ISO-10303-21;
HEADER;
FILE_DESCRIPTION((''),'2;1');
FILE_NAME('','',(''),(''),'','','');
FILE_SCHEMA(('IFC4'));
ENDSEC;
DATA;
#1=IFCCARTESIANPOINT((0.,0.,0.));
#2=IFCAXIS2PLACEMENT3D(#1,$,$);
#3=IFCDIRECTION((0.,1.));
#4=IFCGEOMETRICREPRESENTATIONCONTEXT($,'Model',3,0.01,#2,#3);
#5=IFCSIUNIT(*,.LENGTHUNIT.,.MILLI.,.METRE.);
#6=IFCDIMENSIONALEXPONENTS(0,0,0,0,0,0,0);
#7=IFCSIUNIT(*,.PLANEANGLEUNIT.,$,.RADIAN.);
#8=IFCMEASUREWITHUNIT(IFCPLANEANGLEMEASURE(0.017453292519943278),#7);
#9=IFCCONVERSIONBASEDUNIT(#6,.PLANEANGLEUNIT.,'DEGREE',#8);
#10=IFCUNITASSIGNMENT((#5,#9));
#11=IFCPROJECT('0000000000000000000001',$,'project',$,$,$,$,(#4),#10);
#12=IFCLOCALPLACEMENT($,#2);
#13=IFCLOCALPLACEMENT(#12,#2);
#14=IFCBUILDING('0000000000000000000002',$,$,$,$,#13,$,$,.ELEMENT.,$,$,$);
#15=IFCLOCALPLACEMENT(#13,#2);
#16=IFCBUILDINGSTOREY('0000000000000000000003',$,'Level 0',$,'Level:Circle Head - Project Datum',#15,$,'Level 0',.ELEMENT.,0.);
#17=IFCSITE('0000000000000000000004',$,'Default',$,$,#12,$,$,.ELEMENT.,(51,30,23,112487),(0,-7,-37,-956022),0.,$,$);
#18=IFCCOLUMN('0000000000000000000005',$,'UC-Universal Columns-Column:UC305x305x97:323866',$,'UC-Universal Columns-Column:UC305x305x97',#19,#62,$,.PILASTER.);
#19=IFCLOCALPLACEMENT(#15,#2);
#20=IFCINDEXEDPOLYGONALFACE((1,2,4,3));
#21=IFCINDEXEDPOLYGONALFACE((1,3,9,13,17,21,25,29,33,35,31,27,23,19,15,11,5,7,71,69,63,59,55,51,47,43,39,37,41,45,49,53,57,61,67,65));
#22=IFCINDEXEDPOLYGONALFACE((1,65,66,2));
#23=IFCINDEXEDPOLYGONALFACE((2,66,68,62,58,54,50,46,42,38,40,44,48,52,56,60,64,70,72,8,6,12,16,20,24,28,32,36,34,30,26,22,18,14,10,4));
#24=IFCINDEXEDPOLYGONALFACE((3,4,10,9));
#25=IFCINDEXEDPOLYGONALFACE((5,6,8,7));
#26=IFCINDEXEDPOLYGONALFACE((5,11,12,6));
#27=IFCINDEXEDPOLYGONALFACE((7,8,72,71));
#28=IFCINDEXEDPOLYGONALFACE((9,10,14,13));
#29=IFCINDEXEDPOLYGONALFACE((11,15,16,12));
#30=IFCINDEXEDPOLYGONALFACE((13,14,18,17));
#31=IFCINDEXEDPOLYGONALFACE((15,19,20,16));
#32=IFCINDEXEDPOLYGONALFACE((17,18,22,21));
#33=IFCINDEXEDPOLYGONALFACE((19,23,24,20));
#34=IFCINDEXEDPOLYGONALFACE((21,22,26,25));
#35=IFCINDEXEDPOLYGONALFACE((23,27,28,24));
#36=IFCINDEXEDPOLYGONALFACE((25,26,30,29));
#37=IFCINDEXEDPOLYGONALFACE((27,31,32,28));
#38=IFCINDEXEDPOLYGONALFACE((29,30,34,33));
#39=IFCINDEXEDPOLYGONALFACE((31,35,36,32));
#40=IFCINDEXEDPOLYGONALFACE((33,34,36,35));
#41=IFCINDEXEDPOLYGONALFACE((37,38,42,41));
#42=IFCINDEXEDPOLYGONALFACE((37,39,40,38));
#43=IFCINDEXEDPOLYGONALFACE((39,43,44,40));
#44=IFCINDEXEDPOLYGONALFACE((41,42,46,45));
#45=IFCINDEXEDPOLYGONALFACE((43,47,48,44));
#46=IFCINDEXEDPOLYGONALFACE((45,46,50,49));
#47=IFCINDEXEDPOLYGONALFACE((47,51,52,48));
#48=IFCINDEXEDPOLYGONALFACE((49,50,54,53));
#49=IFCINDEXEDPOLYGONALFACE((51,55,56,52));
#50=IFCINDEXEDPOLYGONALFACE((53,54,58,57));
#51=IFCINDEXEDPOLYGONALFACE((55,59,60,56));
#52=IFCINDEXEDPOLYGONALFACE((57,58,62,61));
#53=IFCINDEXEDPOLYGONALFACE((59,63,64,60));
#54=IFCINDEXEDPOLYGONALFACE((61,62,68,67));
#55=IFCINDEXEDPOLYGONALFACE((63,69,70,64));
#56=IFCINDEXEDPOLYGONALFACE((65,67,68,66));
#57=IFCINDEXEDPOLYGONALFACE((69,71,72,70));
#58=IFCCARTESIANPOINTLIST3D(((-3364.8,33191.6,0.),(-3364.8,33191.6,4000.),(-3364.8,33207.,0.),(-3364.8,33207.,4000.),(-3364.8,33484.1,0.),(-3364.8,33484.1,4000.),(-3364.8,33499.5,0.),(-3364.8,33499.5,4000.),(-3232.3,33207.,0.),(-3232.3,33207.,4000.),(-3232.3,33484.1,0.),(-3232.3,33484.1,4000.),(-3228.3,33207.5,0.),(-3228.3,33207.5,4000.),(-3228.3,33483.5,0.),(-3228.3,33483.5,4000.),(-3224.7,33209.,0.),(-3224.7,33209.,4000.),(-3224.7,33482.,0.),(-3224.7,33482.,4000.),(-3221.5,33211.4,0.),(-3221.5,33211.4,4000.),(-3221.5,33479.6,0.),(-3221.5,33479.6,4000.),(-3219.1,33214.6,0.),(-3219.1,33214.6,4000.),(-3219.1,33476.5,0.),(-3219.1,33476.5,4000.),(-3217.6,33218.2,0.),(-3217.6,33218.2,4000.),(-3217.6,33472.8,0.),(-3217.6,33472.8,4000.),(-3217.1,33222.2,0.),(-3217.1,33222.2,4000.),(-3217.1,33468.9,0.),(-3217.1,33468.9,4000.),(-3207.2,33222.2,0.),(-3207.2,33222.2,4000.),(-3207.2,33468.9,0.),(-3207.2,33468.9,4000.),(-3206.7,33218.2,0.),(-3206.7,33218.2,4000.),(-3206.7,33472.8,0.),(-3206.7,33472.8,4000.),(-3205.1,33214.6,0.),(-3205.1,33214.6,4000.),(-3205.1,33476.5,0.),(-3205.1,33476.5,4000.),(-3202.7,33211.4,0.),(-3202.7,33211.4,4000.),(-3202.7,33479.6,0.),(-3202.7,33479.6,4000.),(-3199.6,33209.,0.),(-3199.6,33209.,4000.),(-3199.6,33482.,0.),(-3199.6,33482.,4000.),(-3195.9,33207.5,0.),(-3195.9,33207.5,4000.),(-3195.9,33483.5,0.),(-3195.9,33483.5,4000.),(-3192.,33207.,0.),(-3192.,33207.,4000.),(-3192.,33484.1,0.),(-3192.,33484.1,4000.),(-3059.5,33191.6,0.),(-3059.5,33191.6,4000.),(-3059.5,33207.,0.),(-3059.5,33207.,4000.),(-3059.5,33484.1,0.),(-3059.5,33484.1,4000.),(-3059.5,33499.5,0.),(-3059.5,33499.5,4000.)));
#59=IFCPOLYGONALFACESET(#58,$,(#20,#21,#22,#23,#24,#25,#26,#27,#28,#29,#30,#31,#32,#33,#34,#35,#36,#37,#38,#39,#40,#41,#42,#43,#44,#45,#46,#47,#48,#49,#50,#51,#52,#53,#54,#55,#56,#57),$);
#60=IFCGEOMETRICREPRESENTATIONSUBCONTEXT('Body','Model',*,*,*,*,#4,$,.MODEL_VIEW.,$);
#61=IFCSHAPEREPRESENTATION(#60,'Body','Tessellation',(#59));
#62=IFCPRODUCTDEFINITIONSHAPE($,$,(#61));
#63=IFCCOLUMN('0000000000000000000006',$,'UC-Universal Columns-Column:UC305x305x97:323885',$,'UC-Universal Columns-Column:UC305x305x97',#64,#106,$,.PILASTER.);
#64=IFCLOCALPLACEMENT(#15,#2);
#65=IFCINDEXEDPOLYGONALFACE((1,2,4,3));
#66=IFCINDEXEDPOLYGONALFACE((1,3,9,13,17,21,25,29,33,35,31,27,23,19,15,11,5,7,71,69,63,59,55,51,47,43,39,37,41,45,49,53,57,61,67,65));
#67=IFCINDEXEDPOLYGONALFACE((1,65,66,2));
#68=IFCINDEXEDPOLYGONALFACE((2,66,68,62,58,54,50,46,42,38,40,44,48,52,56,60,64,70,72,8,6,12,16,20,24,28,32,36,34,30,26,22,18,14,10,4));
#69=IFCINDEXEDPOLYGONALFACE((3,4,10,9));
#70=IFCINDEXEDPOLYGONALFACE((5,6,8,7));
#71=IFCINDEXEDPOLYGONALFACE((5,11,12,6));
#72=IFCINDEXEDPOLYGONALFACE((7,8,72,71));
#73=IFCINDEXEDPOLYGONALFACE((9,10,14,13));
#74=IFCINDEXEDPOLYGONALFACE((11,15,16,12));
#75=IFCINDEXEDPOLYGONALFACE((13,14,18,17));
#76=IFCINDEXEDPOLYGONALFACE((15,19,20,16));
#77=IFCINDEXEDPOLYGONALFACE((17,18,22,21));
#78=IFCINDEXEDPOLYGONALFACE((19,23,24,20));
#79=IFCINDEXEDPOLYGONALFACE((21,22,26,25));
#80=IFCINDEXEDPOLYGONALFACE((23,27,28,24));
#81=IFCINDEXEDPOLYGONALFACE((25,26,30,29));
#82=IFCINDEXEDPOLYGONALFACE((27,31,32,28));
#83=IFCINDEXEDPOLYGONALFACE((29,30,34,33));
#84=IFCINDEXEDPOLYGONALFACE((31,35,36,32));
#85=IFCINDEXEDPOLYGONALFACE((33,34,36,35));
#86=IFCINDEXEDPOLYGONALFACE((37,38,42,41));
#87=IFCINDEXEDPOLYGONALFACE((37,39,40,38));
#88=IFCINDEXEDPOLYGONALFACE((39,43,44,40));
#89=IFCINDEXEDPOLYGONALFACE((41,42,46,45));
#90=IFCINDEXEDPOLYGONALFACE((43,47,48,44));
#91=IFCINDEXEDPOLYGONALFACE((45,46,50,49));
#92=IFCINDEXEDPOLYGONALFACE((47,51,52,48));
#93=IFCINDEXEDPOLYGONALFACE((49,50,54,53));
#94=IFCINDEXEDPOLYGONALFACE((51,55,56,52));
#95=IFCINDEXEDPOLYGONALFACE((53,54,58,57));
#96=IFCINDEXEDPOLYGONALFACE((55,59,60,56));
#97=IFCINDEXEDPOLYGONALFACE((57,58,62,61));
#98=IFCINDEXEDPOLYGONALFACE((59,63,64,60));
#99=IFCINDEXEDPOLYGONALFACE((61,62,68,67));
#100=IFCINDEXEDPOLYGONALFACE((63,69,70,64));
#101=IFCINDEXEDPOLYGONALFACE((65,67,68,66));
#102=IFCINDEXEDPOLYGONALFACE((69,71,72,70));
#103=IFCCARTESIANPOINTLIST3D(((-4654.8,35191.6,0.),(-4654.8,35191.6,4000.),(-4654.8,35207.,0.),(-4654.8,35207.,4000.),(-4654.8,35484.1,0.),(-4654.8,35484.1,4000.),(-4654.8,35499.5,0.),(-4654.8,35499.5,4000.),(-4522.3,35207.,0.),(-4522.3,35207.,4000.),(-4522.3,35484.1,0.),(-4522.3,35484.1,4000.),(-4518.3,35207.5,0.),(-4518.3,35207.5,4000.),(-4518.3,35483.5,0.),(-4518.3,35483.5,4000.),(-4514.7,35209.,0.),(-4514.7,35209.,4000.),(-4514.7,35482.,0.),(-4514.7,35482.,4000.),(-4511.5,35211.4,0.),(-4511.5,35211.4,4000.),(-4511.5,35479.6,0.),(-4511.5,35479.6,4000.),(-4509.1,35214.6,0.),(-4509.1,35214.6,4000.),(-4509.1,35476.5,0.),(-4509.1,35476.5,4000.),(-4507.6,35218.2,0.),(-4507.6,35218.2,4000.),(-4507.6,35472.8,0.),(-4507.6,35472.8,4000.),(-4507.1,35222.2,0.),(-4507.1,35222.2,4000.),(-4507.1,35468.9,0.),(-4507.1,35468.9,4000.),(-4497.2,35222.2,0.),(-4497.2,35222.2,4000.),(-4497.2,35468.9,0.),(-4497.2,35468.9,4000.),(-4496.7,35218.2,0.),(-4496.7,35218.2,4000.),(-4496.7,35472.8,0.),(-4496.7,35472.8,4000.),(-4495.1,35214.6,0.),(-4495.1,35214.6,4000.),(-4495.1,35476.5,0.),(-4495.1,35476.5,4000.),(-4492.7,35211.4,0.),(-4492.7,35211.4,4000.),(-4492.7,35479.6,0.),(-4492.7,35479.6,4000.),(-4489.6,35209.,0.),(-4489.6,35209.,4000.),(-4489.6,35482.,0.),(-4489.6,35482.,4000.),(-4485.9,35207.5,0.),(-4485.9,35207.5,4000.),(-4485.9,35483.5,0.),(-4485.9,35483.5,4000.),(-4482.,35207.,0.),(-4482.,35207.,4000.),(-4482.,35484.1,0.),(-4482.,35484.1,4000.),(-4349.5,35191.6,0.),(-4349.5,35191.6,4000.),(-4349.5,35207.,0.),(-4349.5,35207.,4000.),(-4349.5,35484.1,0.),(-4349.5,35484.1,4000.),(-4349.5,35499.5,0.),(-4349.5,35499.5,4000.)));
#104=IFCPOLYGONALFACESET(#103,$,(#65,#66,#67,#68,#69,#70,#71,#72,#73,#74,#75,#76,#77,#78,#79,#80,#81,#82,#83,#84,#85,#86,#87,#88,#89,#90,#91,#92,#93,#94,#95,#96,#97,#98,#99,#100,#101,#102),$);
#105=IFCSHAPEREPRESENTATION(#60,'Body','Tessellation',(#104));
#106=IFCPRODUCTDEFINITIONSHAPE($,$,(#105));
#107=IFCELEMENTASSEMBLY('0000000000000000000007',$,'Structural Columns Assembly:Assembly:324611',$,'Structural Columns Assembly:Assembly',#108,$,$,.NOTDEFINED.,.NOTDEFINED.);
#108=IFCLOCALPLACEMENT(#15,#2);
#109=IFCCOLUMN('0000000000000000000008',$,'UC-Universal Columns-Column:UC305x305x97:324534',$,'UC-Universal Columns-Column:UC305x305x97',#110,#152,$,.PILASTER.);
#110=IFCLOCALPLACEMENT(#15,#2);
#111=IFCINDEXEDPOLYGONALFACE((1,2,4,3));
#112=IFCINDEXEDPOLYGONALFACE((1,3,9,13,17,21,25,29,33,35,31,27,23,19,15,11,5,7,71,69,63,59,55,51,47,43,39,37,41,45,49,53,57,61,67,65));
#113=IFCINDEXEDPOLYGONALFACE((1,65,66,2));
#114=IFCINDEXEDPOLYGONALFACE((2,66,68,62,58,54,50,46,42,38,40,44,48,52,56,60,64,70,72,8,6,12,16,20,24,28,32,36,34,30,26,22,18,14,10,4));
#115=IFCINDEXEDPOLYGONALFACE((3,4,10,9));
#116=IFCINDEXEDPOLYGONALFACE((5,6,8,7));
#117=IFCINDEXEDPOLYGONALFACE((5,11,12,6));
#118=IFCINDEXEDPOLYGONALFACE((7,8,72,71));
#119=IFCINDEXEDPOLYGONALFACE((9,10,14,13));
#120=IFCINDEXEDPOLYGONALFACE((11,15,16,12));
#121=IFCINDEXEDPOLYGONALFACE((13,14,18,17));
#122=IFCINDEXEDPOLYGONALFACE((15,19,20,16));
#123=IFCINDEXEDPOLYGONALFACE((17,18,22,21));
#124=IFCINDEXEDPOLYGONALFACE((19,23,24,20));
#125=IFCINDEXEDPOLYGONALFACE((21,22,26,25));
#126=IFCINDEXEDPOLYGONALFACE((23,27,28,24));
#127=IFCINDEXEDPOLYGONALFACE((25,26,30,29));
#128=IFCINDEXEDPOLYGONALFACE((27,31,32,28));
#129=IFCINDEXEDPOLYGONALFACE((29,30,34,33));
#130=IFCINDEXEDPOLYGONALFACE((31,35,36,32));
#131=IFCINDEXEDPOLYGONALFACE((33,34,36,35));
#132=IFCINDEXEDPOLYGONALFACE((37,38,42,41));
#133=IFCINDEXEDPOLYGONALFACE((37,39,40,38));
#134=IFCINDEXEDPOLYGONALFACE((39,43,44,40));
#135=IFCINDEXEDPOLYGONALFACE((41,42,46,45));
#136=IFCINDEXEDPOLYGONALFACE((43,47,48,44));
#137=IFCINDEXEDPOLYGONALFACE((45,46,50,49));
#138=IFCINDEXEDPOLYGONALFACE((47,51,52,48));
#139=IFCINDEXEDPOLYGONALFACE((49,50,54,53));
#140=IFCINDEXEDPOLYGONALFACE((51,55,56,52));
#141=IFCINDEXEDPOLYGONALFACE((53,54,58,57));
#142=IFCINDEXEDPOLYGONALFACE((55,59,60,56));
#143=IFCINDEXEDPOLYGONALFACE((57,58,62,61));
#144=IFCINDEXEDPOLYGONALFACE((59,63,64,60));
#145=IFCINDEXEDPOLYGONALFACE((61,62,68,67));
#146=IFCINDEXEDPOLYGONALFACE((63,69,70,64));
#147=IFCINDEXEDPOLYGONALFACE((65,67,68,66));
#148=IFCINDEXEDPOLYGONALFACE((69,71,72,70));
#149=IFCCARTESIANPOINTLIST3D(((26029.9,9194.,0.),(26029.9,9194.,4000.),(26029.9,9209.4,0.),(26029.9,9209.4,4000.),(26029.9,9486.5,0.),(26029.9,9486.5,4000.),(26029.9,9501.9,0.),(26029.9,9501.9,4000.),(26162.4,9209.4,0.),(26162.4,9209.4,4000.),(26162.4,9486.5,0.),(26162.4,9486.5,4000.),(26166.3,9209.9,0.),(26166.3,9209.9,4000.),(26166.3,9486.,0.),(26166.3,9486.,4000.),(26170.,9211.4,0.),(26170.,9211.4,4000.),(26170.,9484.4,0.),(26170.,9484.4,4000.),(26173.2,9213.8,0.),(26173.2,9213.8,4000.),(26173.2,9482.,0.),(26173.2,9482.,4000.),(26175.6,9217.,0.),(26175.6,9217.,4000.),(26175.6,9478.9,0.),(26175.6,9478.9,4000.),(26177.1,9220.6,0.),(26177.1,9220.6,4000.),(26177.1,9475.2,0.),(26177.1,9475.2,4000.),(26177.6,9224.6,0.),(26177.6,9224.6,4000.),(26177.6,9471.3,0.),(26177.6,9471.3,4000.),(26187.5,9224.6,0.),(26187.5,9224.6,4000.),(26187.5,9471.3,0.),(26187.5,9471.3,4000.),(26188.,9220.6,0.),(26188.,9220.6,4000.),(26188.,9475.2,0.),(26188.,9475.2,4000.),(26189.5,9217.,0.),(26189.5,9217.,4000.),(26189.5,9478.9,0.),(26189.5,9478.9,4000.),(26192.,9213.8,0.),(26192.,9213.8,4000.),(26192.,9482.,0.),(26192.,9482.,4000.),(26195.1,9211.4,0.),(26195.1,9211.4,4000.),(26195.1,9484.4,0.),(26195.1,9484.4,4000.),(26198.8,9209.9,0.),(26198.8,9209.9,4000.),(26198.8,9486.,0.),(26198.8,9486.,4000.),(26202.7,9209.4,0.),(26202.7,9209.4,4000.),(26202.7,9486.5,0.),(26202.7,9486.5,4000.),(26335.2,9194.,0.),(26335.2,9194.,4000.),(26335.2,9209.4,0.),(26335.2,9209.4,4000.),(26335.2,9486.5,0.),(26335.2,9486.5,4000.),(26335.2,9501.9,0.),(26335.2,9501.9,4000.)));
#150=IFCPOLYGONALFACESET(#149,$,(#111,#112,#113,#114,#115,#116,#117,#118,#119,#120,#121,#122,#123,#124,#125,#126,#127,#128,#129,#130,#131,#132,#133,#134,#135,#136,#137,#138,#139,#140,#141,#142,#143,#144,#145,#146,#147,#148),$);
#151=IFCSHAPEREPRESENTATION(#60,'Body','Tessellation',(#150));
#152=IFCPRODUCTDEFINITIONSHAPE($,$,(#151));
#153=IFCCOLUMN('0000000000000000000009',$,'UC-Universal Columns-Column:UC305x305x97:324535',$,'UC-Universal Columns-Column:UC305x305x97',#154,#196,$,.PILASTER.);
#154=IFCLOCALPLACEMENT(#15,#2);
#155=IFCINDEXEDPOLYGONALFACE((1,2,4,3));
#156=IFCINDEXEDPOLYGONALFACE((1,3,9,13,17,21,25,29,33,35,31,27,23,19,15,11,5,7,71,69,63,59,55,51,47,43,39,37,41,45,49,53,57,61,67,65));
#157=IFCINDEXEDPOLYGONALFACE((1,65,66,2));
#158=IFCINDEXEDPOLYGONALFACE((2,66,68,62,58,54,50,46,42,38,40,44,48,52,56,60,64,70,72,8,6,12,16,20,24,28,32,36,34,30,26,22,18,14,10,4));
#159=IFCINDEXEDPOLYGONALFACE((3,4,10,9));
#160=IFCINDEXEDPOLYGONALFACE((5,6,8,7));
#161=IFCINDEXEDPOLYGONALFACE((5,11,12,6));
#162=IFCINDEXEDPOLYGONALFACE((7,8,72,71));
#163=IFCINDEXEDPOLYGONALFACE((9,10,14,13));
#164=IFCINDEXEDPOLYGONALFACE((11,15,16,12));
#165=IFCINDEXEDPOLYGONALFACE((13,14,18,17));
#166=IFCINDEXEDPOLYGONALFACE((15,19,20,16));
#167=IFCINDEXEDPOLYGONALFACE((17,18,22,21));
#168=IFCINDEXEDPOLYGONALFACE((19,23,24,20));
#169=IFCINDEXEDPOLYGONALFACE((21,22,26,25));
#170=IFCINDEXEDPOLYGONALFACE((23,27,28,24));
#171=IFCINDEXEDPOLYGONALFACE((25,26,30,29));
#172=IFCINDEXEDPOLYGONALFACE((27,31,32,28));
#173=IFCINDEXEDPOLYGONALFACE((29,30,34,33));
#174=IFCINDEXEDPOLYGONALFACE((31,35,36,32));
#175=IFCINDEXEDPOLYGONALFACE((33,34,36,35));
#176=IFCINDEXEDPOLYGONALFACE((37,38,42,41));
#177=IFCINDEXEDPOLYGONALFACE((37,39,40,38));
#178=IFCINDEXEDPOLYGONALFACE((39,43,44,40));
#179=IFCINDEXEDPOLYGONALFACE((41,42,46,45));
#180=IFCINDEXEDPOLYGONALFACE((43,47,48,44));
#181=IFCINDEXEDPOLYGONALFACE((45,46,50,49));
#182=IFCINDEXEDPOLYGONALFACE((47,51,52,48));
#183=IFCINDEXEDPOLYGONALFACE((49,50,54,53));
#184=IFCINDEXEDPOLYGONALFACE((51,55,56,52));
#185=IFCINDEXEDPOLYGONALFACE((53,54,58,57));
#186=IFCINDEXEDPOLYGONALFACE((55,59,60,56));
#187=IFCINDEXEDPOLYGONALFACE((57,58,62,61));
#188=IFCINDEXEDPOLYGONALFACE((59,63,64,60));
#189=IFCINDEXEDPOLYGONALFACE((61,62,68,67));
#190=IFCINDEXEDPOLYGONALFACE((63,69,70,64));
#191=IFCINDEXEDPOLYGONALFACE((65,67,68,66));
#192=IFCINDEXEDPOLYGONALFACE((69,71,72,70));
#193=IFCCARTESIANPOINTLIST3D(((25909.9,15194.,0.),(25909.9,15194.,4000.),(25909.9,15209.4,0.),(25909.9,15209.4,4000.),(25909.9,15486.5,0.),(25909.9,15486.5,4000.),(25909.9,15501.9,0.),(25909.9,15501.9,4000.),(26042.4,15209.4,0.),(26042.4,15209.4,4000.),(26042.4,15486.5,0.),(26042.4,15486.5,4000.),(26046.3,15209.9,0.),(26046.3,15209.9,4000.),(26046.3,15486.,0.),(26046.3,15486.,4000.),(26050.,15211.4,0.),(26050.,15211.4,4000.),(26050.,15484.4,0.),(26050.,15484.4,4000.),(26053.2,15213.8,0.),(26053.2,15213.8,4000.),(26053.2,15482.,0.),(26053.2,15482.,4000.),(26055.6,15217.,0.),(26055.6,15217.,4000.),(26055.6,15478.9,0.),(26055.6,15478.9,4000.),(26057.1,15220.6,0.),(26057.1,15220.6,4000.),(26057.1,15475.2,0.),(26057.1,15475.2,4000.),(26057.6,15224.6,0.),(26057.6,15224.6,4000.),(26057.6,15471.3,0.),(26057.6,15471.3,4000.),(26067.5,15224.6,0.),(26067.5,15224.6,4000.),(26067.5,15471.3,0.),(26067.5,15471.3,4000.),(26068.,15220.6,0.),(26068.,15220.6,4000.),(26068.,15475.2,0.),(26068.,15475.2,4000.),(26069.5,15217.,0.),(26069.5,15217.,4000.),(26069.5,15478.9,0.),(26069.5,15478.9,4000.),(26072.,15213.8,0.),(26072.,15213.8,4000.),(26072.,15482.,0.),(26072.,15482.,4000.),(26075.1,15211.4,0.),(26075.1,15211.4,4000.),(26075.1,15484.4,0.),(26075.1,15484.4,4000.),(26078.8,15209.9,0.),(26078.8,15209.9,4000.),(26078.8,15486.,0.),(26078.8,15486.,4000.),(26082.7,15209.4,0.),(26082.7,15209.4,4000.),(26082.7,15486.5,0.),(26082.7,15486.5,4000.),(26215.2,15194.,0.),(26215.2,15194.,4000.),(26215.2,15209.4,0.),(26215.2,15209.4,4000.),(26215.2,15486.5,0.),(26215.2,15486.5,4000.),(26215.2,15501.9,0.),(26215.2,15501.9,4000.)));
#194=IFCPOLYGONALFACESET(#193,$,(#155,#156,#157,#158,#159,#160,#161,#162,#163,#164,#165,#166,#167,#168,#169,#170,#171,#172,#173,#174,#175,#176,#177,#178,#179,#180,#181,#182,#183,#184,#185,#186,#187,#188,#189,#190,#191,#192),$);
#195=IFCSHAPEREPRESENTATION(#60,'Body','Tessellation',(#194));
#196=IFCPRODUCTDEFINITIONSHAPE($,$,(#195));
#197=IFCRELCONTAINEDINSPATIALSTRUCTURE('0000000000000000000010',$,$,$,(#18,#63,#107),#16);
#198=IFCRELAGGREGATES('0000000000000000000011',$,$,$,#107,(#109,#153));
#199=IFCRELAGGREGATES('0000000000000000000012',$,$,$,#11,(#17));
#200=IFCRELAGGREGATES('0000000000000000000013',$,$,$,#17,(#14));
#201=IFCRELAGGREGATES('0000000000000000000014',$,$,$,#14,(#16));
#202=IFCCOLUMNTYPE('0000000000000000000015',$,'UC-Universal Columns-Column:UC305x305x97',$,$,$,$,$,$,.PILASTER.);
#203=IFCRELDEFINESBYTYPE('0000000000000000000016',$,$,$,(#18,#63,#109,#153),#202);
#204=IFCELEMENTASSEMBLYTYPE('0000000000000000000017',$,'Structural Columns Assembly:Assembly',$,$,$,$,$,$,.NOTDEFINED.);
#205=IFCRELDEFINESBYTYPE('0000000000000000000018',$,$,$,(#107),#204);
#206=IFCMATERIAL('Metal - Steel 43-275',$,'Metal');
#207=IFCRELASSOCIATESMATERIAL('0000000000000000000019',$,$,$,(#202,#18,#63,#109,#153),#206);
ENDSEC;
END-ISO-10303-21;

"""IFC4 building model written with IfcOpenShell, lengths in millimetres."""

from ifc_helpers import new_model, entity, si_unit, converted_unit, direction, frame, origin, place, context, subcontext, project, spatial, line, arc, indexed_curve, outline, extrude, source, transform, mapped, material, type_object, type_shapes, element, aggregate, save


model = new_model("IFC4")

# Units and contexts
model_context = context("Model", 3, precision=0.01, world=origin(), true_north=direction((0.0, 1.0)))
body_context = subcontext(model_context, "Body", "Model", "MODEL_VIEW")
ifc_project = project(units=[si_unit("LENGTHUNIT", "METRE", prefix="MILLI"), converted_unit("PLANEANGLEUNIT", "DEGREE", entity("IfcPlaneAngleMeasure", 0.017453292519943278), si_unit("PLANEANGLEUNIT", "RADIAN"), dimensions=[0, 0, 0, 0, 0, 0, 0])], contexts=[model_context])

# Site, building, storey
site_placement = place(None, origin())
site = spatial("IfcSite", under=ifc_project, at=site_placement, Name="Default", CompositionType="ELEMENT", RefLatitude=(51, 30, 23, 112487), RefLongitude=(0, -7, -37, -956022), RefElevation=0.0)
building_placement = place(site_placement, origin())
building = spatial("IfcBuilding", under=site, at=building_placement, CompositionType="ELEMENT")
storey_placement = place(building_placement, origin())
storey = spatial("IfcBuildingStorey", under=building, at=storey_placement, Name="Level 0", ObjectType="Level:Circle Head - Project Datum", LongName="Level 0", CompositionType="ELEMENT", Elevation=0.0)

# Columns
ifc_material_1 = material(Name="Metal - Steel 43-275", Category="Metal")
column_type = type_object("IfcColumnType", Name="UC-Universal Columns-Column:UC305x305x97", PredefinedType="PILASTER", material=ifc_material_1)
shared_shape_1 = source(origin(), body_context, "Body", "SweptSolid", [
    extrude(outline(indexed_curve([(-152.6, -153.9), (152.6, -153.9), (152.6, -138.5), (20.2, -138.5), (9.4, -134.1), (4.9, -123.4), (4.9, 123.3), (9.4, 134.1), (20.1, 138.5), (152.6, 138.5), (152.6, 153.9), (-152.6, 153.9), (-152.6, 138.5), (-20.2, 138.6), (-9.4, 134.1), (-5.0, 123.4), (-5.0, -123.3), (-9.4, -134.1), (-20.2, -138.5), (-152.6, -138.5)], segments=[line(1, 2, 3, 4), arc(4, 5, 6), line(6, 7), arc(7, 8, 9), line(9, 10, 11, 12, 13, 14), arc(14, 15, 16), line(16, 17), arc(17, 18, 19), line(19, 20, 1)], self_intersect=False)), frame((0.0, 0.0, 0.0), z_axis=(0.0, 0.0, 1.0), x_axis=(-1.0, 0.0, 0.0)), (0.0, 0.0, 1.0), 4000.0),
])
type_shapes(column_type, [shared_shape_1])
for number, where, name in (
    (1, (-3212.1, 33345.5, 0.0), "UC-Universal Columns-Column:UC305x305x97:323866"),
    (2, (-4502.1, 35345.5, 0.0), "UC-Universal Columns-Column:UC305x305x97:323885"),
):
    element("IfcColumn", number, at=place(storey_placement, frame(where)), inside=storey, type_object=column_type, material=ifc_material_1, Name=name, ObjectType="UC-Universal Columns-Column:UC305x305x97", PredefinedType="PILASTER", context=body_context, shape_type="MappedRepresentation", body=[
        mapped(shared_shape_1, transform((0.0, 0.0, 0.0), scale=1.0)),
    ])

# Element assembly, columns
element_assembly_type = type_object("IfcElementAssemblyType", Name="Structural Columns Assembly:Assembly", PredefinedType="NOTDEFINED")
assembly_placement = place(storey_placement, origin())
assembly = element("IfcElementAssembly", 3, at=assembly_placement, inside=storey, type_object=element_assembly_type, Name="Structural Columns Assembly:Assembly:324611", ObjectType="Structural Columns Assembly:Assembly", AssemblyPlace="NOTDEFINED", PredefinedType="NOTDEFINED")
column_1_placement = place(assembly_placement, frame((26182.6, 9347.9, 0.0)))
column_1 = element("IfcColumn", 4, at=column_1_placement, type_object=column_type, material=ifc_material_1, Name="UC-Universal Columns-Column:UC305x305x97:324534", ObjectType="UC-Universal Columns-Column:UC305x305x97", PredefinedType="PILASTER", context=body_context, shape_type="MappedRepresentation", body=[
    mapped(shared_shape_1, transform((0.0, 0.0, 0.0), scale=1.0)),
])
column_2_placement = place(assembly_placement, frame((26062.6, 15347.9, 0.0)))
column_2 = element("IfcColumn", 5, at=column_2_placement, type_object=column_type, material=ifc_material_1, Name="UC-Universal Columns-Column:UC305x305x97:324535", ObjectType="UC-Universal Columns-Column:UC305x305x97", PredefinedType="PILASTER", context=body_context, shape_type="MappedRepresentation", body=[
    mapped(shared_shape_1, transform((0.0, 0.0, 0.0), scale=1.0)),
])
aggregate(assembly, [column_1, column_2])

save(model, "model.ifc")
